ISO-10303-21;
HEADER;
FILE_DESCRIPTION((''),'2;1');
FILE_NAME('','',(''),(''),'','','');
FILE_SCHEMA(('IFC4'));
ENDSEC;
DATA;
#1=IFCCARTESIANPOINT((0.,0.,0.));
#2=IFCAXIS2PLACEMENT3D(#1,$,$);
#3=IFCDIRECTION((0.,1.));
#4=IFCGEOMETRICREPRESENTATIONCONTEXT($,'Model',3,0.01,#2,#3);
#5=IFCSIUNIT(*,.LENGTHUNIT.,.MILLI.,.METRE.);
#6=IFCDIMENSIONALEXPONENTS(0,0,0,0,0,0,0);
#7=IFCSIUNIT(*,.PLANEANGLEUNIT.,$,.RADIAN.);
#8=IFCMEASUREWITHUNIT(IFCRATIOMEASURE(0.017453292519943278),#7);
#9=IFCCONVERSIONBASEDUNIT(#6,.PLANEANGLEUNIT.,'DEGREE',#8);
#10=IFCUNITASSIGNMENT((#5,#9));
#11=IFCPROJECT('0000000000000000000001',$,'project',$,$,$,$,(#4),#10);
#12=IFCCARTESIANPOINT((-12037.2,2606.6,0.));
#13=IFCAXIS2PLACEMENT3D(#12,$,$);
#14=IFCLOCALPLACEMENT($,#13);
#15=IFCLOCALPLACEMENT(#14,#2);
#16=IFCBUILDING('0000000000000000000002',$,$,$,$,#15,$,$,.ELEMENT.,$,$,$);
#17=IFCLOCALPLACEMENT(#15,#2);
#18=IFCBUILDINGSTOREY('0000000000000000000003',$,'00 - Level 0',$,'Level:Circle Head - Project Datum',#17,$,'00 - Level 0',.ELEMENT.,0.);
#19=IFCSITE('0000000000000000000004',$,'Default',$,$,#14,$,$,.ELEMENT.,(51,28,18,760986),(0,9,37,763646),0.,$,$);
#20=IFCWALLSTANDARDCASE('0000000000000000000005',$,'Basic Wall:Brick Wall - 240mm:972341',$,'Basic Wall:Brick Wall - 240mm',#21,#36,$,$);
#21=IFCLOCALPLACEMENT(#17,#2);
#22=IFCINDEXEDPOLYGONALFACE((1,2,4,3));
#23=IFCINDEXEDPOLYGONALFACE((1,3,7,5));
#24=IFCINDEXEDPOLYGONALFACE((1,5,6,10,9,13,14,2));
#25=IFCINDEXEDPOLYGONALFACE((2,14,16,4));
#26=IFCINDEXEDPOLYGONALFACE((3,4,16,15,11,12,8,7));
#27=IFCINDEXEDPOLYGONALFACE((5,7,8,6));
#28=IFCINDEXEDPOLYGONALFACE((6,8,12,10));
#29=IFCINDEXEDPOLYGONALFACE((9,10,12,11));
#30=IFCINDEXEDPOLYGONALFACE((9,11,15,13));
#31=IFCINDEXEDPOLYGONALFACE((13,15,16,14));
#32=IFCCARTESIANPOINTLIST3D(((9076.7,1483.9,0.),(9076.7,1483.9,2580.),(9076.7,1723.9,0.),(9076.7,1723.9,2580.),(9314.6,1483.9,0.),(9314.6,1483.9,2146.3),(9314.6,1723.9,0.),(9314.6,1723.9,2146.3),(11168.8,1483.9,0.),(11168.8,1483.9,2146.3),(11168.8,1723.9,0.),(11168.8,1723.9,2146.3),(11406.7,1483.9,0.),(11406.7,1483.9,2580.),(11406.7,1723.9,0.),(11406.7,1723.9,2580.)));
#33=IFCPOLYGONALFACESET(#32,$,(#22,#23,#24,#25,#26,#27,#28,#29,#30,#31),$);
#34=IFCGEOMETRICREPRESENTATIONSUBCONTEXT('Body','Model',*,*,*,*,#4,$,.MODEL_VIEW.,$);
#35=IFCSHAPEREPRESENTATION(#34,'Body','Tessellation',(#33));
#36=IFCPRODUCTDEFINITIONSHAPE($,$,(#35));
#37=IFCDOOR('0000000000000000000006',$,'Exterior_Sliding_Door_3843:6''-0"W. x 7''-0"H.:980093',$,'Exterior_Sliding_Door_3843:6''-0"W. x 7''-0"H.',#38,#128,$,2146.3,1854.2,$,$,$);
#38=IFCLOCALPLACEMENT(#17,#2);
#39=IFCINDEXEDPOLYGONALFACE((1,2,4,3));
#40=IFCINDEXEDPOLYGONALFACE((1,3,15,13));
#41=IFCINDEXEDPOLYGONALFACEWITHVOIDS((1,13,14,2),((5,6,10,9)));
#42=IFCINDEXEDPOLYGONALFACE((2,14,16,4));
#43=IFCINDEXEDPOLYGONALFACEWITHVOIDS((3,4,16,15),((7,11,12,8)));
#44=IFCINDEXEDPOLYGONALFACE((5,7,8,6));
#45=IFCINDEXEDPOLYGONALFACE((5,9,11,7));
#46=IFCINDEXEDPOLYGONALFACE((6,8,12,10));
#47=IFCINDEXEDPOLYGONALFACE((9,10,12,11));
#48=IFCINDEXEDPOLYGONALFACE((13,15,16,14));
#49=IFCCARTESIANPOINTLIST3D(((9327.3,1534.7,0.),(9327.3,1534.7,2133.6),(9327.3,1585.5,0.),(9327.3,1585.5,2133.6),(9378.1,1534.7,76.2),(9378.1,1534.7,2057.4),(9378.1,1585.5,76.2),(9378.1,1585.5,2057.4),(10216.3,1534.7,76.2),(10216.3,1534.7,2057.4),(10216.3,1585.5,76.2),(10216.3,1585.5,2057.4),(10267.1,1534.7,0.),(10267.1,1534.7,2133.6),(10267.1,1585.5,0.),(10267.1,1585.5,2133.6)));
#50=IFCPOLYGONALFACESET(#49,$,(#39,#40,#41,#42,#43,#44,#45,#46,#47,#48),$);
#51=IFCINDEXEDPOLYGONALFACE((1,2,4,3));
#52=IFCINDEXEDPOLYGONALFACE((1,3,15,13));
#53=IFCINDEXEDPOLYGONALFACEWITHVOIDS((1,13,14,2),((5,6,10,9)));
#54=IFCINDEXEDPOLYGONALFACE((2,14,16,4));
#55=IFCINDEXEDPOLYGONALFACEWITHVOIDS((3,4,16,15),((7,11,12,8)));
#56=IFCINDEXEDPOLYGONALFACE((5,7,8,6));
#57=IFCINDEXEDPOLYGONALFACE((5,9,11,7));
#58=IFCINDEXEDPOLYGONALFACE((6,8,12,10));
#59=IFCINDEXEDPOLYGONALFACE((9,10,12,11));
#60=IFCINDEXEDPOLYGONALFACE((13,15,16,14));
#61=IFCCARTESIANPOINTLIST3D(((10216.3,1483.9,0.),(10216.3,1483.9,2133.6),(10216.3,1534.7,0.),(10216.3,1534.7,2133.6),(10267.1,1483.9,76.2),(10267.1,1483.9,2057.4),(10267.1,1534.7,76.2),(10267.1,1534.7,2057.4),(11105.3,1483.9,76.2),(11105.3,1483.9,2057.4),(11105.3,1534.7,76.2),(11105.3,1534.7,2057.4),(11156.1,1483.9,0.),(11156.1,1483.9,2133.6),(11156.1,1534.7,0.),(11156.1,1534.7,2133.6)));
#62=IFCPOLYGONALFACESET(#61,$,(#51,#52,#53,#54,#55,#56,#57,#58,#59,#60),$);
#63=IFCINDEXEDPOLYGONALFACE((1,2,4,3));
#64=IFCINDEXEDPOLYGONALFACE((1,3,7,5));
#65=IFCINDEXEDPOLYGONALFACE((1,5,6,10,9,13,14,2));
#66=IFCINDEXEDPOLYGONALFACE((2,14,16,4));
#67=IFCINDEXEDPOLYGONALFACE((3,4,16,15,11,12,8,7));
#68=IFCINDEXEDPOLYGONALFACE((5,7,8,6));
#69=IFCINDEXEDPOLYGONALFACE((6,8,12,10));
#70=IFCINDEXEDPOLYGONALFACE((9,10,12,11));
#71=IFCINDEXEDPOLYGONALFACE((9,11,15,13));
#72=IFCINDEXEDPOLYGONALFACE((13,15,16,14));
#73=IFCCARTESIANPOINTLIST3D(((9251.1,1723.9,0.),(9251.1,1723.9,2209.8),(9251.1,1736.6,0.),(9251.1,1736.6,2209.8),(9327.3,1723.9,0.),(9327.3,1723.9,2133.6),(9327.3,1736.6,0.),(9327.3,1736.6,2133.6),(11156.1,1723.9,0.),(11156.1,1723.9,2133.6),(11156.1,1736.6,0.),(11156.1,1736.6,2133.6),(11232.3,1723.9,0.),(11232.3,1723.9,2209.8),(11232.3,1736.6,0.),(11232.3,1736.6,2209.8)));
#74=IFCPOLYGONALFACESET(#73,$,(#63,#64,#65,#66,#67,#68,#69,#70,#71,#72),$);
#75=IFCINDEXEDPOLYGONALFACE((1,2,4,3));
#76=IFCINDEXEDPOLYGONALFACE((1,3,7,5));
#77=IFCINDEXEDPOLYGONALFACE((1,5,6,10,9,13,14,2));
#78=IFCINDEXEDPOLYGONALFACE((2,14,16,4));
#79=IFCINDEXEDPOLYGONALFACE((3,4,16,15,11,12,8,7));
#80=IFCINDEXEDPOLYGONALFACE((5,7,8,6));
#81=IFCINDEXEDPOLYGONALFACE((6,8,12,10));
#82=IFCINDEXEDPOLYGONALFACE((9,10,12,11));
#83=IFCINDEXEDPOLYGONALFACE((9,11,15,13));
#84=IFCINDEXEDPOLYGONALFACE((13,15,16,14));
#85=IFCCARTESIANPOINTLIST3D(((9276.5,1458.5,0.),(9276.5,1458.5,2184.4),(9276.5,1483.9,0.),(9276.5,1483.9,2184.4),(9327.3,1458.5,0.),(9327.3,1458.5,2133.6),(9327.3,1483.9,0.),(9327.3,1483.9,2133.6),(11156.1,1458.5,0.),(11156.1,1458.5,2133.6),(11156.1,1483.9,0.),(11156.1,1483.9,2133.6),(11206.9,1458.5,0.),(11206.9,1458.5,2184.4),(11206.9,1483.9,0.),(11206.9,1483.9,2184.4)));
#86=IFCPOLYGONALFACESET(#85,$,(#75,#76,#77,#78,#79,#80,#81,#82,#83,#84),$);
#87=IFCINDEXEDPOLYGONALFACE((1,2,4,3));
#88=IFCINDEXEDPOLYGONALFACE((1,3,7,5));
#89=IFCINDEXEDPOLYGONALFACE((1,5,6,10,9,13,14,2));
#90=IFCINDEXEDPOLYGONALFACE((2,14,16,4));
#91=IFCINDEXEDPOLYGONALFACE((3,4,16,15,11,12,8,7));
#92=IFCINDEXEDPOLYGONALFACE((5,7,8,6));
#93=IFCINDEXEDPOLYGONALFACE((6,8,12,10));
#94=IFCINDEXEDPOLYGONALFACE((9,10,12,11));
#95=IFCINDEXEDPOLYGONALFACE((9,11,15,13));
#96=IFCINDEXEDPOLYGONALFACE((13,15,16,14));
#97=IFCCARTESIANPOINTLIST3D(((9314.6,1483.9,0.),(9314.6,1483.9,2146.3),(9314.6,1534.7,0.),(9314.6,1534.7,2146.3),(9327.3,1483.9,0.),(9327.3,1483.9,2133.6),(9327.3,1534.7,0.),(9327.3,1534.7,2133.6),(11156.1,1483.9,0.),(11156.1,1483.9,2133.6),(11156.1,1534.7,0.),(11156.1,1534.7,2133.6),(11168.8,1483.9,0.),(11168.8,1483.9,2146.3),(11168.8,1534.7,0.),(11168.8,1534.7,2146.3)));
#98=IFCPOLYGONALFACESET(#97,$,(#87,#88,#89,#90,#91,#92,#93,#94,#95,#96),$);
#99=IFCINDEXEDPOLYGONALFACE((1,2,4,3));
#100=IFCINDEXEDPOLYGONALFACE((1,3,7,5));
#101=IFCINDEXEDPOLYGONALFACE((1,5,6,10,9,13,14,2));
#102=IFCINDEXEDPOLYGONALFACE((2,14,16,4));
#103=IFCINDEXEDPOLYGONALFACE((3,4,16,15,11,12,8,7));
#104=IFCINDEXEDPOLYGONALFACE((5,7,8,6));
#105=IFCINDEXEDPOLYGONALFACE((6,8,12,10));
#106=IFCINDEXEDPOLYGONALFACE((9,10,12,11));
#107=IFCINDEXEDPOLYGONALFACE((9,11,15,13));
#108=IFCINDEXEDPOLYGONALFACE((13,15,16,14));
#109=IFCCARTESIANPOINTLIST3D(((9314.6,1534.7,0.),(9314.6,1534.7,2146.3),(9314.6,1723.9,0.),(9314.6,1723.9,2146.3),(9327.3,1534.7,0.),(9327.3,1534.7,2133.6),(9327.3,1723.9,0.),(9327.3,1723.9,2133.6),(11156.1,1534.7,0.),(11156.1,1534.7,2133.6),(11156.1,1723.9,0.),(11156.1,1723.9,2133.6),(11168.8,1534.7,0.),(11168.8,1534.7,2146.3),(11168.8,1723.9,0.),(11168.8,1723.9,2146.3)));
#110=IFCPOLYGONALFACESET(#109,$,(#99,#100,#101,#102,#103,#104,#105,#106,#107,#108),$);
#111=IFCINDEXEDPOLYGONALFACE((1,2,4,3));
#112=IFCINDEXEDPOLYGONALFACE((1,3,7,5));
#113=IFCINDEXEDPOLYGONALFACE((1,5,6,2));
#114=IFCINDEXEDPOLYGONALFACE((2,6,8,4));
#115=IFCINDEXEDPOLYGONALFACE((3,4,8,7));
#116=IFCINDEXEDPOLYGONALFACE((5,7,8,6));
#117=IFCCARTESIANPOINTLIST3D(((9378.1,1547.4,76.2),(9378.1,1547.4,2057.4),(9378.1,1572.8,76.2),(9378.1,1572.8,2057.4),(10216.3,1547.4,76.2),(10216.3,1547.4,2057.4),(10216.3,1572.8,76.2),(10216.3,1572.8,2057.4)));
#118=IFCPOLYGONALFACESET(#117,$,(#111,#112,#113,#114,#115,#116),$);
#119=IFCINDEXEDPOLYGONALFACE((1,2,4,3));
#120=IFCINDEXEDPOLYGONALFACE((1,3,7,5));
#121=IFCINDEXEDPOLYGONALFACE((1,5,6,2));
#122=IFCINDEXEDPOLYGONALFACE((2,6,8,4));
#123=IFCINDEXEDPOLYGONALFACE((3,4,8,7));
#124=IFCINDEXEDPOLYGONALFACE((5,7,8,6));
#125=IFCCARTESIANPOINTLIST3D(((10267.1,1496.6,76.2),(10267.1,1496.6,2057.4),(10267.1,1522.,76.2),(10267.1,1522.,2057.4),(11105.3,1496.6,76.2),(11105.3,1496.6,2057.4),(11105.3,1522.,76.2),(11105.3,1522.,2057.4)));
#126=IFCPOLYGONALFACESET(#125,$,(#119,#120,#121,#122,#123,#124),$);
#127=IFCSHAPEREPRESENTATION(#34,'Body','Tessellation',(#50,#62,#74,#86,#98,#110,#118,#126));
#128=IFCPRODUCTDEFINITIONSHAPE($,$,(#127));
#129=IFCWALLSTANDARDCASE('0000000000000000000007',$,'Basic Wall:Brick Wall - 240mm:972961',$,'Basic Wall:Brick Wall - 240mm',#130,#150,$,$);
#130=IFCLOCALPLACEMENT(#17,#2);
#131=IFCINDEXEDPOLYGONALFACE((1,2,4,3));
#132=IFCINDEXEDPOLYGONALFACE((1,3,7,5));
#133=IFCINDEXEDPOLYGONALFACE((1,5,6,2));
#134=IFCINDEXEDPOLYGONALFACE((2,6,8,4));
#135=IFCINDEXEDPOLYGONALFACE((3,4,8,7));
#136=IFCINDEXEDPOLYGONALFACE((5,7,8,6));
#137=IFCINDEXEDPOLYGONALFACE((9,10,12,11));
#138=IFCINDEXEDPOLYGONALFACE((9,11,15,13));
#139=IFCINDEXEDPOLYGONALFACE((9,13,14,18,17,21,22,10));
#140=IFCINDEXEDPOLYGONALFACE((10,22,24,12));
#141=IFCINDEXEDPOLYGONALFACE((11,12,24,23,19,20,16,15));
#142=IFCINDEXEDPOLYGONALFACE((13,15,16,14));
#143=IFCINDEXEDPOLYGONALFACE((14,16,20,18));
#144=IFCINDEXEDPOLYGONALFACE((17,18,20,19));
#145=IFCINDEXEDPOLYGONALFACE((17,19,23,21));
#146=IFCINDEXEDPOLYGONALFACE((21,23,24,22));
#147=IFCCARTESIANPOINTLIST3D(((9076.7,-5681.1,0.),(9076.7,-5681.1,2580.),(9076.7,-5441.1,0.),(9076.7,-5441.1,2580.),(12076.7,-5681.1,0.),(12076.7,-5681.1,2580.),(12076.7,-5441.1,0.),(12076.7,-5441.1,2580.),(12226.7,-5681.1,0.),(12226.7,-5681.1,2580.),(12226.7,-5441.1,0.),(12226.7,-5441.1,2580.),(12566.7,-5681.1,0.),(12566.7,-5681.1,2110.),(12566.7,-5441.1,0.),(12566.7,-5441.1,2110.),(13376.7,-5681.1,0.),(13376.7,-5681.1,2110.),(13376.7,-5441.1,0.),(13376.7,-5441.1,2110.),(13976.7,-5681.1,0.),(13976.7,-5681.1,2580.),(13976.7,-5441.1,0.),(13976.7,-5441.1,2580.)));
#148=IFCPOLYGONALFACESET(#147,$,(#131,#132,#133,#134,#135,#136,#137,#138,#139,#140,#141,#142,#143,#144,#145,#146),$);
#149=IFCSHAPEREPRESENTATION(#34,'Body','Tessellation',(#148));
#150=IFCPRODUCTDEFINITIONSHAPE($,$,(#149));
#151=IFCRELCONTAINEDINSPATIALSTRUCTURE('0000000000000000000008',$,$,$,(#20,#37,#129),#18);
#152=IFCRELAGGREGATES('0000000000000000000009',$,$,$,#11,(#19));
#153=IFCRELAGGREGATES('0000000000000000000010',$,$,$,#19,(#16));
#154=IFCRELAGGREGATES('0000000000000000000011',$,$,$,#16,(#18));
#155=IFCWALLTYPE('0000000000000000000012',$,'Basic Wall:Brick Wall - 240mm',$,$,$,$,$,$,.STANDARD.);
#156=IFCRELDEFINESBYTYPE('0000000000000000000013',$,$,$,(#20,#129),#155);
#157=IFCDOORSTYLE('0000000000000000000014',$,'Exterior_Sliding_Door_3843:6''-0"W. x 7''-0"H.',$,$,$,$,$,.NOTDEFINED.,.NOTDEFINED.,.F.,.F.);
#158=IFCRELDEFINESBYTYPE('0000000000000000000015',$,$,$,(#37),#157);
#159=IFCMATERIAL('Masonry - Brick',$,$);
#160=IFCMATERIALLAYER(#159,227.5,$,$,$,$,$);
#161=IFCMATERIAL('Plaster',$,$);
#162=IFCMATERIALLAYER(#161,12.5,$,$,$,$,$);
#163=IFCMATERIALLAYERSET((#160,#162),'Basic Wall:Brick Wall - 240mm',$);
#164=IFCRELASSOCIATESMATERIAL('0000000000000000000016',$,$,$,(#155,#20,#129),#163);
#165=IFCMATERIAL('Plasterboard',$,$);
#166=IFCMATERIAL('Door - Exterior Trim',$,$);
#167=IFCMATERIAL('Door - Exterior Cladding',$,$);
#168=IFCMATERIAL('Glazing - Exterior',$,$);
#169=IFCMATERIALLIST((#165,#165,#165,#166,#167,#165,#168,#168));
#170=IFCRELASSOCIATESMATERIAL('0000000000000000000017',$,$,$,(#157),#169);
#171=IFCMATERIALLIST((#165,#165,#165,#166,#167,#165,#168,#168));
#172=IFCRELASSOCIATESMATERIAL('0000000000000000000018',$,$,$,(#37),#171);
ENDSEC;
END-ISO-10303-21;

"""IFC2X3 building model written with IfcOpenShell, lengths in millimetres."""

from ifc_helpers import new_model, entity, si_unit, converted_unit, direction, frame, frame_2d, origin, place, context, subcontext, project, spatial, polyline, rectangle, outline, extrude, source, transform, mapped, material, material_list, layer, layer_set, layer_usage, type_object, type_shapes, element, fill, save


model = new_model("IFC2X3")

# Units and contexts
model_context = context("Model", 3, precision=0.01, world=origin(), true_north=direction((0.0, 1.0)))
body_context = subcontext(model_context, "Body", "Model", "MODEL_VIEW")
ifc_project = project(units=[si_unit("LENGTHUNIT", "METRE", prefix="MILLI"), converted_unit("PLANEANGLEUNIT", "DEGREE", entity("IfcRatioMeasure", 0.017453292519943278), si_unit("PLANEANGLEUNIT", "RADIAN"), dimensions=[0, 0, 0, 0, 0, 0, 0])], contexts=[model_context])

# Site, building, storey
site_placement = place(None, frame((-12037.2, 2606.6, 0.0)))
site = spatial("IfcSite", under=ifc_project, at=site_placement, Name="Default", CompositionType="ELEMENT", RefLatitude=(51, 28, 18, 760986), RefLongitude=(0, 9, 37, 763646), RefElevation=0.0)
building_placement = place(site_placement, origin())
building = spatial("IfcBuilding", under=site, at=building_placement, CompositionType="ELEMENT")
storey_placement = place(building_placement, origin())
storey = spatial("IfcBuildingStorey", under=building, at=storey_placement, Name="00 - Level 0", ObjectType="Level:Circle Head - Project Datum", LongName="00 - Level 0", CompositionType="ELEMENT", Elevation=0.0)

# Shared definitions
ifc_material_1 = material(Name="Plasterboard")
ifc_material_2 = material(Name="Masonry - Brick")
ifc_material_3 = material(Name="Plaster")

# Shared definitions
ifc_layer_1 = layer(ifc_material_2, 227.5)
ifc_layer_2 = layer(ifc_material_3, 12.5)
ifc_layer_set_1 = layer_set([ifc_layer_1, ifc_layer_2], Name="Basic Wall:Brick Wall - 240mm")
wall_type_1 = type_object("IfcWallType", Name="Basic Wall:Brick Wall - 240mm", PredefinedType="STANDARD", material=ifc_layer_set_1)

# Wall, opening, door
ifc_layer_usage_1 = layer_usage(ifc_layer_set_1, "AXIS2", "NEGATIVE", 120.0)
wall_1_placement = place(storey_placement, frame((9076.7, 1603.9, 0.0)))
wall_1 = element("IfcWallStandardCase", 1, at=wall_1_placement, inside=storey, type_object=wall_type_1, material=ifc_layer_usage_1, Name="Basic Wall:Brick Wall - 240mm:972341", ObjectType="Basic Wall:Brick Wall - 240mm", context=body_context, shape_type="SweptSolid", body=[
    extrude(rectangle(XDim=2330.0, YDim=240.0, at=frame_2d((1165.0, 0.0), x_axis=(1.0, 0.0))), origin(), (0.0, 0.0, 1.0), 2580.0),
])
opening_1_placement = place(wall_1_placement, frame((2092.1, 120.0, 0.0)))
opening_1 = element("IfcOpeningElement", 2, at=opening_1_placement, cuts=wall_1, ObjectType="Opening", context=body_context, shape_type="SweptSolid", body=[
    extrude(rectangle(XDim=2146.3, YDim=1854.2, at=frame_2d((1073.1, 927.1), x_axis=(-1.0, 0.0))), frame((0.0, 0.0, 0.0), z_axis=(0.0, -1.0, 0.0), x_axis=(0.0, 0.0, 1.0)), (0.0, 0.0, 1.0), 240.0),
])
ifc_material_4 = material(Name="Door - Exterior Trim")
ifc_material_5 = material(Name="Door - Exterior Cladding")
ifc_material_6 = material(Name="Glazing - Exterior")
ifc_material_list_1 = material_list([ifc_material_1, ifc_material_1, ifc_material_1, ifc_material_4, ifc_material_5, ifc_material_1, ifc_material_6, ifc_material_6])
ifc_material_list_2 = material_list([ifc_material_1, ifc_material_1, ifc_material_1, ifc_material_4, ifc_material_5, ifc_material_1, ifc_material_6, ifc_material_6])
door_style = type_object("IfcDoorStyle", Name="Exterior_Sliding_Door_3843:6'-0\"W. x 7'-0\"H.", ConstructionType="NOTDEFINED", OperationType="NOTDEFINED", ParameterTakesPrecedence=False, Sizeable=False, material=ifc_material_list_2)
shared_shape_1 = source(origin(), body_context, "Body", "SweptSolid", [
    extrude(outline(polyline([(-469.9, -1066.8), (469.9, -1066.8), (469.9, 1066.8), (-469.9, 1066.8), (-469.9, -1066.8)]), holes=[polyline([(-419.1, -990.6), (-419.1, 990.6), (419.1, 990.6), (419.1, -990.6), (-419.1, -990.6)])]), frame((1371.6, 138.4, 1066.8), z_axis=(0.0, 1.0, 0.0), x_axis=(1.0, 0.0, 0.0)), (0.0, 0.0, 1.0), 50.8),
    extrude(outline(polyline([(-1066.8, -469.9), (1066.8, -469.9), (1066.8, 469.9), (-1066.8, 469.9), (-1066.8, -469.9)]), holes=[polyline([(-990.6, -419.1), (-990.6, 419.1), (990.6, 419.1), (990.6, -419.1), (-990.6, -419.1)])]), frame((482.6, 189.2, 1066.8), z_axis=(0.0, 1.0, 0.0), x_axis=(0.0, 0.0, -1.0)), (0.0, 0.0, 1.0), 50.8),
    extrude(outline(polyline([(-1085.8, -990.6), (1123.9, -990.6), (1123.9, 990.6), (-1085.8, 990.6), (-1085.8, 914.4), (1047.7, 914.4), (1047.7, -914.4), (-1085.8, -914.4), (-1085.8, -990.6)])), frame((927.1, -12.7, 1085.8), z_axis=(0.0, 1.0, 0.0), x_axis=(0.0, 0.0, 1.0)), (0.0, 0.0, 1.0), 12.7),
    extrude(outline(polyline([(-965.2, -1079.5), (-914.4, -1079.5), (-914.4, 1054.1), (914.4, 1054.1), (914.4, -1079.5), (965.2, -1079.5), (965.2, 1104.9), (-965.2, 1104.9), (-965.2, -1079.5)])), frame((927.1, 240.0, 1079.5), z_axis=(0.0, 1.0, 0.0), x_axis=(-1.0, 0.0, 0.0)), (0.0, 0.0, 1.0), 25.4),
    extrude(outline(polyline([(-1070.0, -914.4), (-1070.0, -927.1), (1076.3, -927.1), (1076.3, 927.1), (-1070.0, 927.1), (-1070.0, 914.4), (1063.6, 914.4), (1063.6, -914.4), (-1070.0, -914.4)])), frame((927.1, 189.2, 1070.0), z_axis=(0.0, -1.0, 0.0), x_axis=(0.0, 0.0, 1.0)), (0.0, 0.0, -1.0), 50.8),
    extrude(outline(polyline([(-1070.0, -914.4), (-1070.0, -927.1), (1076.3, -927.1), (1076.3, 927.1), (-1070.0, 927.1), (-1070.0, 914.4), (1063.6, 914.4), (1063.6, -914.4), (-1070.0, -914.4)])), frame((927.1, 0.0, 1070.0), z_axis=(0.0, -1.0, 0.0), x_axis=(0.0, 0.0, 1.0)), (0.0, 0.0, -1.0), 189.2),
    extrude(rectangle(XDim=25.4, YDim=838.2, at=frame_2d((0.0, 0.0), x_axis=(1.0, 0.0))), frame((1371.6, 163.8, 76.2), z_axis=(0.0, 0.0, 1.0), x_axis=(0.0, 1.0, 0.0)), (0.0, 0.0, 1.0), 1981.2),
    extrude(rectangle(XDim=25.4, YDim=838.2, at=frame_2d((0.0, 0.0), x_axis=(1.0, 0.0))), frame((482.6, 214.6, 76.2), z_axis=(0.0, 0.0, 1.0), x_axis=(0.0, -1.0, 0.0)), (0.0, 0.0, 1.0), 1981.2),
])
type_shapes(door_style, [shared_shape_1])
door_placement = place(opening_1_placement, frame((0.0, 0.0, 0.0), z_axis=(0.0, 0.0, 1.0), x_axis=(-1.0, 0.0, 0.0)))
door = element("IfcDoor", 3, at=door_placement, inside=storey, type_object=door_style, material=ifc_material_list_1, Name="Exterior_Sliding_Door_3843:6'-0\"W. x 7'-0\"H.:980093", ObjectType="Exterior_Sliding_Door_3843:6'-0\"W. x 7'-0\"H.", OverallHeight=2146.3, OverallWidth=1854.2, context=body_context, shape_type="MappedRepresentation", body=[
    mapped(shared_shape_1, transform((0.0, 0.0, 0.0), scale=1.0)),
])
fill(opening_1, door)

# Wall, openings
ifc_layer_usage_2 = layer_usage(ifc_layer_set_1, "AXIS2", "NEGATIVE", 120.0)
wall_2_placement = place(storey_placement, frame((13976.7, -5561.1, 0.0), z_axis=(0.0, 0.0, 1.0), x_axis=(-1.0, 0.0, 0.0)))
wall_2 = element("IfcWallStandardCase", 4, at=wall_2_placement, inside=storey, type_object=wall_type_1, material=ifc_layer_usage_2, Name="Basic Wall:Brick Wall - 240mm:972961", ObjectType="Basic Wall:Brick Wall - 240mm", context=body_context, shape_type="SweptSolid", body=[
    extrude(rectangle(XDim=4900.0, YDim=240.0, at=frame_2d((2450.0, 0.0), x_axis=(-1.0, 0.0))), origin(), (0.0, 0.0, 1.0), 2580.0),
])
opening_2_placement = place(storey_placement, frame((13976.7, -5561.1, 0.0), z_axis=(0.0, 0.0, 1.0), x_axis=(-1.0, 0.0, 0.0)))
element("IfcOpeningElement", 5, at=opening_2_placement, cuts=wall_2, ObjectType="Opening", context=body_context, shape_type="SweptSolid", body=[
    extrude(rectangle(XDim=2580.0, YDim=240.0, at=frame_2d((-257.2, -24.0), x_axis=(1.0, 0.0))), frame((1900.0, 24.0, 1547.2), z_axis=(-1.0, 0.0, 0.0), x_axis=(0.0, 0.0, 1.0)), (0.0, 0.0, 1.0), 150.0),
])
opening_3_placement = place(wall_2_placement, frame((1410.0, 120.0, 0.0)))
element("IfcOpeningElement", 6, at=opening_3_placement, cuts=wall_2, ObjectType="Opening", context=body_context, shape_type="SweptSolid", body=[
    extrude(rectangle(XDim=2110.0, YDim=810.0, at=frame_2d((1055.0, 405.0), x_axis=(1.0, 0.0))), frame((0.0, 0.0, 0.0), z_axis=(0.0, -1.0, 0.0), x_axis=(0.0, 0.0, 1.0)), (0.0, 0.0, 1.0), 240.0),
])

save(model, "model.ifc")
